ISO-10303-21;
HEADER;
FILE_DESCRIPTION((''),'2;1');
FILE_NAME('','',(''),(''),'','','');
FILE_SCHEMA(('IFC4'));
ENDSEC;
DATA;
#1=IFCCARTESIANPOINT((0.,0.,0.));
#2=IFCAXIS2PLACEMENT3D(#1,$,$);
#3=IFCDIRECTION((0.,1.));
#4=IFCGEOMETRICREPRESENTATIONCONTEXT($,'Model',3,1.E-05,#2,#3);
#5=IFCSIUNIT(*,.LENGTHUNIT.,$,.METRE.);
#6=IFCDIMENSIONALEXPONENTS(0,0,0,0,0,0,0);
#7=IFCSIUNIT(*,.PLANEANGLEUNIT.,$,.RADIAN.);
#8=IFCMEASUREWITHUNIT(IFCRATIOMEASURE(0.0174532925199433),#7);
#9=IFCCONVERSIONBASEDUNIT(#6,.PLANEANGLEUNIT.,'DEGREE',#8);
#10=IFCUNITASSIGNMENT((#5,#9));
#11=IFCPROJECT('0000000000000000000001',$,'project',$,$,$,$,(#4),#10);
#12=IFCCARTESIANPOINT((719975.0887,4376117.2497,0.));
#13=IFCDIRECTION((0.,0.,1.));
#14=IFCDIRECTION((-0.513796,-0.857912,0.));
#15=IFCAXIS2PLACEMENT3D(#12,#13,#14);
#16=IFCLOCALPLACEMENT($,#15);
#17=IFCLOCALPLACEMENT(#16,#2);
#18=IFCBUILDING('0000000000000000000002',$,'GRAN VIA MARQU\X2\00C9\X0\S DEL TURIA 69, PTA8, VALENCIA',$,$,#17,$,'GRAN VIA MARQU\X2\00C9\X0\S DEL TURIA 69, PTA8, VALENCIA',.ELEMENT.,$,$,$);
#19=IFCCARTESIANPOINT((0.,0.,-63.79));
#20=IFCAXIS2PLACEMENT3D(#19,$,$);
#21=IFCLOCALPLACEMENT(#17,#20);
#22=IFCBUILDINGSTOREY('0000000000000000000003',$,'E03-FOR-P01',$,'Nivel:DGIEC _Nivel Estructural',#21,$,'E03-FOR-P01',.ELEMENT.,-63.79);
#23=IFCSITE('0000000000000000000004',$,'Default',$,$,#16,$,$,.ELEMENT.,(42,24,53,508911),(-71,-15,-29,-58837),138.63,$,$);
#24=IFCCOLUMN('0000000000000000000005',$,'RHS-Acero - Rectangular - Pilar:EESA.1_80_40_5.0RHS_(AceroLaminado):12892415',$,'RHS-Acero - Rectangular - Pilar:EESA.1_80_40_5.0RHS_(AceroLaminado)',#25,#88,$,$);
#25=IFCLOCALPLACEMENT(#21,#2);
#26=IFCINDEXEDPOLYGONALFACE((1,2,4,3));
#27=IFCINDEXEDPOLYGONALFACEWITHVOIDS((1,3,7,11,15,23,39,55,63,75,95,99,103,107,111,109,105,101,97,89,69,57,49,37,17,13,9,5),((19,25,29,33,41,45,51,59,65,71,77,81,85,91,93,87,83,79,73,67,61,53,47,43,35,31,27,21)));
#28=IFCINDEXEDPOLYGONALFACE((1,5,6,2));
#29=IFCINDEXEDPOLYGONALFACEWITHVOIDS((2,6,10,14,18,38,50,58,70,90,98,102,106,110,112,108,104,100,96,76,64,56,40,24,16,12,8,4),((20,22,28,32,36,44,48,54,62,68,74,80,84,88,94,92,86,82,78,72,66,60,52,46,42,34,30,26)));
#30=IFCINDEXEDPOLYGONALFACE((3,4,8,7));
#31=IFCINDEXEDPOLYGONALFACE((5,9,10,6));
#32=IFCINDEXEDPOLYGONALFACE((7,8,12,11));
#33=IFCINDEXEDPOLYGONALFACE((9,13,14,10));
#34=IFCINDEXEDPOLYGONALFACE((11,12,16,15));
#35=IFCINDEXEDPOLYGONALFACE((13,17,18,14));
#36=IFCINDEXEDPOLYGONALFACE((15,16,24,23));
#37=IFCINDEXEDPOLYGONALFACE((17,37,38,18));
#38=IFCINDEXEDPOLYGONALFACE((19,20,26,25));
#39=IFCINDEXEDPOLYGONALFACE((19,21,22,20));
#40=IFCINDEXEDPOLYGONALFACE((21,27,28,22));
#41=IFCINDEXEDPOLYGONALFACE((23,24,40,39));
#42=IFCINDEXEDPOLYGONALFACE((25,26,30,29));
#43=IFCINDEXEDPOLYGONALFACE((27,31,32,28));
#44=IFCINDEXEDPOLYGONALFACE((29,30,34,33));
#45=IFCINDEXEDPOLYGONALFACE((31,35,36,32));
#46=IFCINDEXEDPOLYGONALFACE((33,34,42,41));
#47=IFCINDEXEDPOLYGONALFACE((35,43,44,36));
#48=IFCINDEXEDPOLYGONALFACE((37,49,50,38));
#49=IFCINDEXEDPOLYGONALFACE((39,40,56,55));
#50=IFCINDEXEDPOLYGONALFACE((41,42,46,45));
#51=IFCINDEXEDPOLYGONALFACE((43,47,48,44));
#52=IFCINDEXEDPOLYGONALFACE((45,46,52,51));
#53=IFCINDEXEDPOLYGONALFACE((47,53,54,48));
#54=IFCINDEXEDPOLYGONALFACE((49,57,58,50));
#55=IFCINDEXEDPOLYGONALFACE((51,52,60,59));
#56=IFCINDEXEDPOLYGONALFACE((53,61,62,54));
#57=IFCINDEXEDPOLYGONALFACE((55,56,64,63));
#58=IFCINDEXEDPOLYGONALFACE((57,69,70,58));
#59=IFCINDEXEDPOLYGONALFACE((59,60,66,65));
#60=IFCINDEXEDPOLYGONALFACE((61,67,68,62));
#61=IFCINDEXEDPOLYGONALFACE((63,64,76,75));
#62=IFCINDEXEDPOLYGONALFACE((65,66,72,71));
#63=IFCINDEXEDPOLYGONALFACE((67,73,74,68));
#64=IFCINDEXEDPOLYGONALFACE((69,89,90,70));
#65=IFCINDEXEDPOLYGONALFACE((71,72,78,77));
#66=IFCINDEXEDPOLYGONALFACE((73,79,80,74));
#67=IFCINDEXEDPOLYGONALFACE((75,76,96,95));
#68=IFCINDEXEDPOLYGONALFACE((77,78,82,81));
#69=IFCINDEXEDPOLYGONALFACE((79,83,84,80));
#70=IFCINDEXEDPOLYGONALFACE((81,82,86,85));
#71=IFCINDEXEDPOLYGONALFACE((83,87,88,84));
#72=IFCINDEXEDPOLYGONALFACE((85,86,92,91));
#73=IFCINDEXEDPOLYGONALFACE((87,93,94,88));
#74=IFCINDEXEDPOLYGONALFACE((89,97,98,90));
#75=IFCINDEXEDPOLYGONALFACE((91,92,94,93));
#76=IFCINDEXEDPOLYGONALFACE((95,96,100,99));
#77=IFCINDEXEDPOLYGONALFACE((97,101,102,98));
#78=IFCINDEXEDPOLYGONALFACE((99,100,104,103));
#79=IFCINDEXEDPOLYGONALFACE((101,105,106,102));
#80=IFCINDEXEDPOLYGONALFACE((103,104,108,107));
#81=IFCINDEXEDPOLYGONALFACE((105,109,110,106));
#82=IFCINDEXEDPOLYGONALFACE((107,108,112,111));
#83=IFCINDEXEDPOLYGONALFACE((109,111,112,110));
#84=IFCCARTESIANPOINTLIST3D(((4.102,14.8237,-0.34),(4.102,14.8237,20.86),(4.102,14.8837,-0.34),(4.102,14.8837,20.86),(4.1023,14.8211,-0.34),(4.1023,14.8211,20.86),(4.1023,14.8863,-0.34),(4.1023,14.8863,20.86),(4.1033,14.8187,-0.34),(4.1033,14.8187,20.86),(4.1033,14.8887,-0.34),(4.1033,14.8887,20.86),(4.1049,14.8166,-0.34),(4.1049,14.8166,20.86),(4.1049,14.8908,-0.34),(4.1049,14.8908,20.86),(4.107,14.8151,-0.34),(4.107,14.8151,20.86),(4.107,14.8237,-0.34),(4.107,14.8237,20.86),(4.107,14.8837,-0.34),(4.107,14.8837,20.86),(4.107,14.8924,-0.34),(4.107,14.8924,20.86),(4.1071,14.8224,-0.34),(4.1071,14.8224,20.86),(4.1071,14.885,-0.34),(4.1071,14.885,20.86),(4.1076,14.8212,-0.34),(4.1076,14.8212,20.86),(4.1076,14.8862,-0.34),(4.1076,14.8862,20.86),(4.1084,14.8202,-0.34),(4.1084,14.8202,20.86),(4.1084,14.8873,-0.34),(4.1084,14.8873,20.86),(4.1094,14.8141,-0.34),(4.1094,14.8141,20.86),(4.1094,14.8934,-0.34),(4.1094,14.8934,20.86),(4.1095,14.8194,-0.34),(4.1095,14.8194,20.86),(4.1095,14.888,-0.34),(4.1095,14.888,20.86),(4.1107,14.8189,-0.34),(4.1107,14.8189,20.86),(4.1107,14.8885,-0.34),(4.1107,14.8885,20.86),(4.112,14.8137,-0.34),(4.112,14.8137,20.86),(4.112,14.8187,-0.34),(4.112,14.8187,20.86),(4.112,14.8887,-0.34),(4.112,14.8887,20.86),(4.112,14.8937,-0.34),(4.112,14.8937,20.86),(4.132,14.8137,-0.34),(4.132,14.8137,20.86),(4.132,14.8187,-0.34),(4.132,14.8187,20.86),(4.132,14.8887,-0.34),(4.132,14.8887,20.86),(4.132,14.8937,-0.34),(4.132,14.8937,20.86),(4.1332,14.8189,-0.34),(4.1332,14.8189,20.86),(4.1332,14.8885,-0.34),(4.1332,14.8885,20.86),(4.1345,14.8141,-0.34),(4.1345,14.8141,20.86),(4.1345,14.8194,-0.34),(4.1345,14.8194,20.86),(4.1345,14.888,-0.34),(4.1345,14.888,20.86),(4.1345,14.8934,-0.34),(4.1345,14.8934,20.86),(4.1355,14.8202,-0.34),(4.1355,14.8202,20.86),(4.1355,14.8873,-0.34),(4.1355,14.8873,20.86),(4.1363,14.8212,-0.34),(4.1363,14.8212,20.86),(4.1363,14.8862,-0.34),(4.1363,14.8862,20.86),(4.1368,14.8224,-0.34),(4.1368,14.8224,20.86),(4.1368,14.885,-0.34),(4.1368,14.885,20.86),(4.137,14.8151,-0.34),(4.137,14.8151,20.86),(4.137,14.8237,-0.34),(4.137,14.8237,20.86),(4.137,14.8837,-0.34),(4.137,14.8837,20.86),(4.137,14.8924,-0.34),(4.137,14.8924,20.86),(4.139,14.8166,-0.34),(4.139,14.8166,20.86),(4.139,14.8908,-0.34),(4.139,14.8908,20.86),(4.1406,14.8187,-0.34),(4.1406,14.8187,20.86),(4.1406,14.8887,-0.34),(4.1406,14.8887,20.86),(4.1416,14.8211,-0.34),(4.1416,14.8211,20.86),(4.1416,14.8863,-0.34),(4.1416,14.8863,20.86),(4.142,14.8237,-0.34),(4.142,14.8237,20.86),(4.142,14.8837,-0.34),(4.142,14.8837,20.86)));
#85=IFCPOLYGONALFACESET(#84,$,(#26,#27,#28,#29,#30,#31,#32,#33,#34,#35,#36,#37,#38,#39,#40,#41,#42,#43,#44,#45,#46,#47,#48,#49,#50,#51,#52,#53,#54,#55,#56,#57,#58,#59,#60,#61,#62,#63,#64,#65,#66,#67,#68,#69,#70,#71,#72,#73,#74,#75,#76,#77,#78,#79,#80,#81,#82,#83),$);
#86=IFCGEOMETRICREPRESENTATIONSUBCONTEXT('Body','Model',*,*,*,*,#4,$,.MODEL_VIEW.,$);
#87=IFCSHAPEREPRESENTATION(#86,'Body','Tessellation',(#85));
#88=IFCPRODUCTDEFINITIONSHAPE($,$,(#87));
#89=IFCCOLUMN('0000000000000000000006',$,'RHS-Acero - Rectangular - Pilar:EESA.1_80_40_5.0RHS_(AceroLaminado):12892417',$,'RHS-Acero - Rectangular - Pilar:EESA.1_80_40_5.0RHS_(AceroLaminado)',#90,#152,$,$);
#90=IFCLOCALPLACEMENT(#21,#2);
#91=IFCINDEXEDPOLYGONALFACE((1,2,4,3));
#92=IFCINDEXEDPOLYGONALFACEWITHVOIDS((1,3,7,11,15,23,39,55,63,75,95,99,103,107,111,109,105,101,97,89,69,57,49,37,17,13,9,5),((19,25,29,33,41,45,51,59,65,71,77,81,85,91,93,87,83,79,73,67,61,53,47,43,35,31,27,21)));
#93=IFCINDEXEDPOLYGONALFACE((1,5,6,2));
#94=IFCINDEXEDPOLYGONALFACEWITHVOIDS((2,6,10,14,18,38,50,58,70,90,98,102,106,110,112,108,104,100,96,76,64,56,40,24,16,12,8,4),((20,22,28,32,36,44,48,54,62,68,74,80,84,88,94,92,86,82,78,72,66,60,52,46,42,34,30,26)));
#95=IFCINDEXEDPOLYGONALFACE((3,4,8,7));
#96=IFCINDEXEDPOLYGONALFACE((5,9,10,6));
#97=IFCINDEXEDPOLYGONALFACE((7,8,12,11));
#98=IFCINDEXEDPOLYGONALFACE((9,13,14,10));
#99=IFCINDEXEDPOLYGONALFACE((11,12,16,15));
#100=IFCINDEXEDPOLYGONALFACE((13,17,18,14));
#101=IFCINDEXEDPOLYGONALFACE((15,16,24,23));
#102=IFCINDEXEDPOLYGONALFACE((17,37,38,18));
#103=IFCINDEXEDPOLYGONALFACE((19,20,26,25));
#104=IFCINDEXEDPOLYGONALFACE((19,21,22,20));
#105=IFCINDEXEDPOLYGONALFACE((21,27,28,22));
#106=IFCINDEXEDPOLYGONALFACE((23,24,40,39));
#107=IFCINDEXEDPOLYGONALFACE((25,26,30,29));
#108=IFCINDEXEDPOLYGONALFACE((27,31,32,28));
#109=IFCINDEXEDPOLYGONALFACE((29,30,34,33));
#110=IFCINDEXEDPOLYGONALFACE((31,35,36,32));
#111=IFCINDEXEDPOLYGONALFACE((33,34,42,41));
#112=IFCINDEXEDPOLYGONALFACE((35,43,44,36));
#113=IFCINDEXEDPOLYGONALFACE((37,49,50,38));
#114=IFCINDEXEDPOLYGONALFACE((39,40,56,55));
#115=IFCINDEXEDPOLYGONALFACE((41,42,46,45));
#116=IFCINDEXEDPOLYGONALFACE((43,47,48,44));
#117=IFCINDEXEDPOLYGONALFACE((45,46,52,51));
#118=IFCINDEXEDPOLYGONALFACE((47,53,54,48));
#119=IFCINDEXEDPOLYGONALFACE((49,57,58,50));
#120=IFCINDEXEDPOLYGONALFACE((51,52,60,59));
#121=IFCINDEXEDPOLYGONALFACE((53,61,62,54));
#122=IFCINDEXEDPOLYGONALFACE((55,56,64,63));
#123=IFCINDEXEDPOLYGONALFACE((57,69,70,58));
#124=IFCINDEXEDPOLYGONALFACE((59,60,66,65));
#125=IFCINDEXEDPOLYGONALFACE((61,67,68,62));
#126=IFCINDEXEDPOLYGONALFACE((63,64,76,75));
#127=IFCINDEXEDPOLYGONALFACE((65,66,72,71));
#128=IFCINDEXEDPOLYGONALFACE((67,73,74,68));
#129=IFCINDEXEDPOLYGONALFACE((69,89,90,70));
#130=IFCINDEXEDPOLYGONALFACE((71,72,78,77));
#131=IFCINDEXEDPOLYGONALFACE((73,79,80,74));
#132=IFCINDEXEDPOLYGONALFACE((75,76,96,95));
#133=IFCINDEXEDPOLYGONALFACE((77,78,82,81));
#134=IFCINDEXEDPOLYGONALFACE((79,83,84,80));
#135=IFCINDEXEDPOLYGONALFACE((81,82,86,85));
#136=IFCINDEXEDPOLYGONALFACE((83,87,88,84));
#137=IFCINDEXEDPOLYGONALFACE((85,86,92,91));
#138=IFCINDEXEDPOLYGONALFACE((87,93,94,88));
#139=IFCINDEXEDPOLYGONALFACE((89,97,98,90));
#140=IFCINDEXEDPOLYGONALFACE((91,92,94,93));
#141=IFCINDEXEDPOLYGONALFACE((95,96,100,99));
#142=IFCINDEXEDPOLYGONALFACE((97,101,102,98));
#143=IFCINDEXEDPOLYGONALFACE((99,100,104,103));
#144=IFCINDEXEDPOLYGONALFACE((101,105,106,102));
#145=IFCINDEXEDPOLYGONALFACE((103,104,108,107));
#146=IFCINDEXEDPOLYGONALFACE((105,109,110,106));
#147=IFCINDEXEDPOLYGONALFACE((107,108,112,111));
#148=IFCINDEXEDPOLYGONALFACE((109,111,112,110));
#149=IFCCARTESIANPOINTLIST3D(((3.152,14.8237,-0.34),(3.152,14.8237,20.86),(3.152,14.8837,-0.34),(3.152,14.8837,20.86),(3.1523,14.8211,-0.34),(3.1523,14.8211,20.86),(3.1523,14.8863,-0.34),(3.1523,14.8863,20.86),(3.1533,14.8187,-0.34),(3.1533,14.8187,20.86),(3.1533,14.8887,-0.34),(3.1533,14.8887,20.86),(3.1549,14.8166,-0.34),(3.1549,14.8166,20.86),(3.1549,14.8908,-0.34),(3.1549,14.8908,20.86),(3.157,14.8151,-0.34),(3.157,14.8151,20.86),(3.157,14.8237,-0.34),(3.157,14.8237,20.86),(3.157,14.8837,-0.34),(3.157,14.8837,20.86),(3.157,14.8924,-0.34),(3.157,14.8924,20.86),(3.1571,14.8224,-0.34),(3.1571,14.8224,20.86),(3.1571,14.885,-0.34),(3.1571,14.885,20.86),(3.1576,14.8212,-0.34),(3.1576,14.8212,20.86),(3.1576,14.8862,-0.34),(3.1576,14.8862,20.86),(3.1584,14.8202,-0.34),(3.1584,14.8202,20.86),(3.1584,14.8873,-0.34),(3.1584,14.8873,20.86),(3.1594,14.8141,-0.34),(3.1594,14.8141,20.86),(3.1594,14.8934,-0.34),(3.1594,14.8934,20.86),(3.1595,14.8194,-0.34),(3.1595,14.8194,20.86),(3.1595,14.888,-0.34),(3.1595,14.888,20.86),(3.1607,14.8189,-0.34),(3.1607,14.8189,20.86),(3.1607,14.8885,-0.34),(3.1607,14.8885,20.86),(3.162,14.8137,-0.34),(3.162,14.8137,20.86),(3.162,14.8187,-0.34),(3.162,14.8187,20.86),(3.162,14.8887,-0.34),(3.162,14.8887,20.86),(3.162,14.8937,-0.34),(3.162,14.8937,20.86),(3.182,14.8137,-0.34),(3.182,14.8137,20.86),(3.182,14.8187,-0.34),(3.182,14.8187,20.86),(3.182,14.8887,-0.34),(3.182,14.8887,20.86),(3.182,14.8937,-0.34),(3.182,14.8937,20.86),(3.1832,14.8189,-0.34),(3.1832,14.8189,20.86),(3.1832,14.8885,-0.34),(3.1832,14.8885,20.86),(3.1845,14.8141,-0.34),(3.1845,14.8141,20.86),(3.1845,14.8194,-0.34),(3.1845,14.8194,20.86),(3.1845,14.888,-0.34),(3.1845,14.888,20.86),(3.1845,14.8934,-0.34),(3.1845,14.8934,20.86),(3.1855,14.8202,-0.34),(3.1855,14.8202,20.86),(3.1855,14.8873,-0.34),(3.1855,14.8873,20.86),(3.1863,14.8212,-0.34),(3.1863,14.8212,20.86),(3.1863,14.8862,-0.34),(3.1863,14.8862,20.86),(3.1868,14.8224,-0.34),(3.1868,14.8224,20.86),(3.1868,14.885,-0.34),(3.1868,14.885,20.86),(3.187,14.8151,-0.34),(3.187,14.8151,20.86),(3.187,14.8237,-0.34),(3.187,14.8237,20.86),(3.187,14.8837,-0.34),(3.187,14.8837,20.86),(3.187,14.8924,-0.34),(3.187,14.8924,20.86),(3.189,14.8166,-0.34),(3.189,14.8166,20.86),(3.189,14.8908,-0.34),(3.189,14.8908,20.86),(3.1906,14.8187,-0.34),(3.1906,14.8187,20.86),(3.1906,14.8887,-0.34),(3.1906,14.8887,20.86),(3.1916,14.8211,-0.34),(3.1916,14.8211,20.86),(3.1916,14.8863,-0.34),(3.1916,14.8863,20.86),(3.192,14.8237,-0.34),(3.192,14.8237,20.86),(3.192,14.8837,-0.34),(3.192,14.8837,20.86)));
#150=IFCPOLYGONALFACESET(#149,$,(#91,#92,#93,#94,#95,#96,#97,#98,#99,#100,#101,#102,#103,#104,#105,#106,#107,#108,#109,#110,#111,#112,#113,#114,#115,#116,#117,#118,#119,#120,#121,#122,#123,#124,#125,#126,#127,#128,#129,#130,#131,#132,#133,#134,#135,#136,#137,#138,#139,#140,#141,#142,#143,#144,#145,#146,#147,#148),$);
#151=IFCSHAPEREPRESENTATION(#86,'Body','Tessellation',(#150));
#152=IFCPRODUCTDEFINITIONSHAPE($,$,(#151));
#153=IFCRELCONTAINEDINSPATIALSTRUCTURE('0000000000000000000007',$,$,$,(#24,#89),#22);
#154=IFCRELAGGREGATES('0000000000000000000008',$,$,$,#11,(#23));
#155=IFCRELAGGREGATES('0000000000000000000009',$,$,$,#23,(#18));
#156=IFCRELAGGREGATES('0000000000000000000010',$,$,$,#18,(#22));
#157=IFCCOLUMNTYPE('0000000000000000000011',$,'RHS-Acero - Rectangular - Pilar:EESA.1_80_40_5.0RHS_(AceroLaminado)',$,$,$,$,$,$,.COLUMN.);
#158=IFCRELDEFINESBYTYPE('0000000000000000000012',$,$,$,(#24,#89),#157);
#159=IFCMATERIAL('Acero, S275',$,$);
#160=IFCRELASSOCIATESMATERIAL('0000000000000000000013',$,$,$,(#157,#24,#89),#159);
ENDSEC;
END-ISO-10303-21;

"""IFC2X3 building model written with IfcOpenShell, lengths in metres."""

from ifc_helpers import new_model, entity, si_unit, converted_unit, direction, frame, frame_2d, origin, place, context, subcontext, project, spatial, polyline, circle_curve, parameter, trimmed, segment, composite_curve, outline, extrude, source, transform, mapped, material, type_object, type_shapes, element, save


model = new_model("IFC2X3")

# Units and contexts
model_context = context("Model", 3, precision=1e-05, world=origin(), true_north=direction((0.0, 1.0)))
body_context = subcontext(model_context, "Body", "Model", "MODEL_VIEW")
ifc_project = project(units=[si_unit("LENGTHUNIT", "METRE"), converted_unit("PLANEANGLEUNIT", "DEGREE", entity("IfcRatioMeasure", 0.0174532925199433), si_unit("PLANEANGLEUNIT", "RADIAN"), dimensions=[0, 0, 0, 0, 0, 0, 0])], contexts=[model_context])

# Site, building, storey
site_placement = place(None, frame((719975.0887, 4376117.2497, 0.0), z_axis=(0.0, 0.0, 1.0), x_axis=(-0.513796, -0.857912, 0.0)))
site = spatial("IfcSite", under=ifc_project, at=site_placement, Name="Default", CompositionType="ELEMENT", RefLatitude=(42, 24, 53, 508911), RefLongitude=(-71, -15, -29, -58837), RefElevation=138.63)
building_placement = place(site_placement, origin())
building = spatial("IfcBuilding", under=site, at=building_placement, Name="GRAN VIA MARQUÉS DEL TURIA 69, PTA8, VALENCIA", LongName="GRAN VIA MARQUÉS DEL TURIA 69, PTA8, VALENCIA", CompositionType="ELEMENT")
storey_placement = place(building_placement, frame((0.0, 0.0, -63.79)))
storey = spatial("IfcBuildingStorey", under=building, at=storey_placement, Name="E03-FOR-P01", ObjectType="Nivel:DGIEC _Nivel Estructural", LongName="E03-FOR-P01", CompositionType="ELEMENT", Elevation=-63.79)

# Columns
ifc_material_1 = material(Name="Acero, S275")
column_type_1 = type_object("IfcColumnType", Name="RHS-Acero - Rectangular - Pilar:EESA.1_80_40_5.0RHS_(AceroLaminado)", PredefinedType="COLUMN", material=ifc_material_1)
shared_shape_1 = source(origin(), body_context, "Body", "SweptSolid", [
    extrude(outline(composite_curve([segment(polyline([(-0.01, -0.04), (0.01, -0.04)]), True, "CONTINUOUS"), segment(trimmed(circle_curve(frame_2d((0.01, -0.03), x_axis=(-1.0, 0.0)), 0.01), [parameter(90.0)], [parameter(180.0)], True, "PARAMETER"), True, "CONTINUOUS"), segment(polyline([(0.02, -0.03), (0.02, 0.03)]), True, "CONTINUOUS"), segment(trimmed(circle_curve(frame_2d((0.01, 0.03), x_axis=(-1.0, 0.0)), 0.01), [parameter(180.0)], [parameter(270.0)], True, "PARAMETER"), True, "CONTINUOUS"), segment(polyline([(0.01, 0.04), (-0.01, 0.04)]), True, "CONTINUOUS"), segment(trimmed(circle_curve(frame_2d((-0.01, 0.03), x_axis=(-1.0, 0.0)), 0.01), [parameter(270.0)], [parameter(360.0)], True, "PARAMETER"), True, "CONTINUOUS"), segment(polyline([(-0.02, 0.03), (-0.02, -0.03)]), True, "CONTINUOUS"), segment(trimmed(circle_curve(frame_2d((-0.01, -0.03), x_axis=(-1.0, 0.0)), 0.01), [parameter(360.0)], [parameter(90.0)], True, "PARAMETER"), True, "CONTINUOUS")], self_intersect=False), holes=[composite_curve([segment(trimmed(circle_curve(frame_2d((-0.01, -0.03), x_axis=(-1.0, 0.0)), 0.005), [parameter(0.0)], [parameter(90.0)], True, "PARAMETER"), False, "CONTINUOUS"), segment(polyline([(-0.015, -0.03), (-0.015, 0.03)]), True, "CONTINUOUS"), segment(trimmed(circle_curve(frame_2d((-0.01, 0.03), x_axis=(-1.0, 0.0)), 0.005), [parameter(270.0)], [parameter(0.0)], True, "PARAMETER"), False, "CONTINUOUS"), segment(polyline([(-0.01, 0.035), (0.01, 0.035)]), True, "CONTINUOUS"), segment(trimmed(circle_curve(frame_2d((0.01, 0.03), x_axis=(-1.0, 0.0)), 0.005), [parameter(180.0)], [parameter(270.0)], True, "PARAMETER"), False, "CONTINUOUS"), segment(polyline([(0.015, 0.03), (0.015, -0.03)]), True, "CONTINUOUS"), segment(trimmed(circle_curve(frame_2d((0.01, -0.03), x_axis=(-1.0, 0.0)), 0.005), [parameter(90.0)], [parameter(180.0)], True, "PARAMETER"), False, "CONTINUOUS"), segment(polyline([(0.01, -0.035), (-0.01, -0.035)]), True, "CONTINUOUS")], self_intersect=False)]), frame((0.0, 0.0, -64.13), z_axis=(0.0, 0.0, 1.0), x_axis=(-1.0, 0.0, 0.0)), (0.0, 0.0, 1.0), 21.2),
])
type_shapes(column_type_1, [shared_shape_1])
for number, where, z_axis, x_axis, name in (
    (1, (4.122, 14.8537, 63.79), (0.0, 0.0, 1.0), (-1.0, 0.0, 0.0), "RHS-Acero - Rectangular - Pilar:EESA.1_80_40_5.0RHS_(AceroLaminado):12892415"),
    (2, (3.172, 14.8537, 63.79), (0.0, 0.0, 1.0), (-1.0, 0.0, 0.0), "RHS-Acero - Rectangular - Pilar:EESA.1_80_40_5.0RHS_(AceroLaminado):12892417"),
):
    element("IfcColumn", number, at=place(storey_placement, frame(where, z_axis=z_axis, x_axis=x_axis)), inside=storey, type_object=column_type_1, material=ifc_material_1, Name=name, ObjectType="RHS-Acero - Rectangular - Pilar:EESA.1_80_40_5.0RHS_(AceroLaminado)", context=body_context, shape_type="MappedRepresentation", body=[
        mapped(shared_shape_1, transform((0.0, 0.0, 0.0), scale=1.0)),
    ])

save(model, "model.ifc")
